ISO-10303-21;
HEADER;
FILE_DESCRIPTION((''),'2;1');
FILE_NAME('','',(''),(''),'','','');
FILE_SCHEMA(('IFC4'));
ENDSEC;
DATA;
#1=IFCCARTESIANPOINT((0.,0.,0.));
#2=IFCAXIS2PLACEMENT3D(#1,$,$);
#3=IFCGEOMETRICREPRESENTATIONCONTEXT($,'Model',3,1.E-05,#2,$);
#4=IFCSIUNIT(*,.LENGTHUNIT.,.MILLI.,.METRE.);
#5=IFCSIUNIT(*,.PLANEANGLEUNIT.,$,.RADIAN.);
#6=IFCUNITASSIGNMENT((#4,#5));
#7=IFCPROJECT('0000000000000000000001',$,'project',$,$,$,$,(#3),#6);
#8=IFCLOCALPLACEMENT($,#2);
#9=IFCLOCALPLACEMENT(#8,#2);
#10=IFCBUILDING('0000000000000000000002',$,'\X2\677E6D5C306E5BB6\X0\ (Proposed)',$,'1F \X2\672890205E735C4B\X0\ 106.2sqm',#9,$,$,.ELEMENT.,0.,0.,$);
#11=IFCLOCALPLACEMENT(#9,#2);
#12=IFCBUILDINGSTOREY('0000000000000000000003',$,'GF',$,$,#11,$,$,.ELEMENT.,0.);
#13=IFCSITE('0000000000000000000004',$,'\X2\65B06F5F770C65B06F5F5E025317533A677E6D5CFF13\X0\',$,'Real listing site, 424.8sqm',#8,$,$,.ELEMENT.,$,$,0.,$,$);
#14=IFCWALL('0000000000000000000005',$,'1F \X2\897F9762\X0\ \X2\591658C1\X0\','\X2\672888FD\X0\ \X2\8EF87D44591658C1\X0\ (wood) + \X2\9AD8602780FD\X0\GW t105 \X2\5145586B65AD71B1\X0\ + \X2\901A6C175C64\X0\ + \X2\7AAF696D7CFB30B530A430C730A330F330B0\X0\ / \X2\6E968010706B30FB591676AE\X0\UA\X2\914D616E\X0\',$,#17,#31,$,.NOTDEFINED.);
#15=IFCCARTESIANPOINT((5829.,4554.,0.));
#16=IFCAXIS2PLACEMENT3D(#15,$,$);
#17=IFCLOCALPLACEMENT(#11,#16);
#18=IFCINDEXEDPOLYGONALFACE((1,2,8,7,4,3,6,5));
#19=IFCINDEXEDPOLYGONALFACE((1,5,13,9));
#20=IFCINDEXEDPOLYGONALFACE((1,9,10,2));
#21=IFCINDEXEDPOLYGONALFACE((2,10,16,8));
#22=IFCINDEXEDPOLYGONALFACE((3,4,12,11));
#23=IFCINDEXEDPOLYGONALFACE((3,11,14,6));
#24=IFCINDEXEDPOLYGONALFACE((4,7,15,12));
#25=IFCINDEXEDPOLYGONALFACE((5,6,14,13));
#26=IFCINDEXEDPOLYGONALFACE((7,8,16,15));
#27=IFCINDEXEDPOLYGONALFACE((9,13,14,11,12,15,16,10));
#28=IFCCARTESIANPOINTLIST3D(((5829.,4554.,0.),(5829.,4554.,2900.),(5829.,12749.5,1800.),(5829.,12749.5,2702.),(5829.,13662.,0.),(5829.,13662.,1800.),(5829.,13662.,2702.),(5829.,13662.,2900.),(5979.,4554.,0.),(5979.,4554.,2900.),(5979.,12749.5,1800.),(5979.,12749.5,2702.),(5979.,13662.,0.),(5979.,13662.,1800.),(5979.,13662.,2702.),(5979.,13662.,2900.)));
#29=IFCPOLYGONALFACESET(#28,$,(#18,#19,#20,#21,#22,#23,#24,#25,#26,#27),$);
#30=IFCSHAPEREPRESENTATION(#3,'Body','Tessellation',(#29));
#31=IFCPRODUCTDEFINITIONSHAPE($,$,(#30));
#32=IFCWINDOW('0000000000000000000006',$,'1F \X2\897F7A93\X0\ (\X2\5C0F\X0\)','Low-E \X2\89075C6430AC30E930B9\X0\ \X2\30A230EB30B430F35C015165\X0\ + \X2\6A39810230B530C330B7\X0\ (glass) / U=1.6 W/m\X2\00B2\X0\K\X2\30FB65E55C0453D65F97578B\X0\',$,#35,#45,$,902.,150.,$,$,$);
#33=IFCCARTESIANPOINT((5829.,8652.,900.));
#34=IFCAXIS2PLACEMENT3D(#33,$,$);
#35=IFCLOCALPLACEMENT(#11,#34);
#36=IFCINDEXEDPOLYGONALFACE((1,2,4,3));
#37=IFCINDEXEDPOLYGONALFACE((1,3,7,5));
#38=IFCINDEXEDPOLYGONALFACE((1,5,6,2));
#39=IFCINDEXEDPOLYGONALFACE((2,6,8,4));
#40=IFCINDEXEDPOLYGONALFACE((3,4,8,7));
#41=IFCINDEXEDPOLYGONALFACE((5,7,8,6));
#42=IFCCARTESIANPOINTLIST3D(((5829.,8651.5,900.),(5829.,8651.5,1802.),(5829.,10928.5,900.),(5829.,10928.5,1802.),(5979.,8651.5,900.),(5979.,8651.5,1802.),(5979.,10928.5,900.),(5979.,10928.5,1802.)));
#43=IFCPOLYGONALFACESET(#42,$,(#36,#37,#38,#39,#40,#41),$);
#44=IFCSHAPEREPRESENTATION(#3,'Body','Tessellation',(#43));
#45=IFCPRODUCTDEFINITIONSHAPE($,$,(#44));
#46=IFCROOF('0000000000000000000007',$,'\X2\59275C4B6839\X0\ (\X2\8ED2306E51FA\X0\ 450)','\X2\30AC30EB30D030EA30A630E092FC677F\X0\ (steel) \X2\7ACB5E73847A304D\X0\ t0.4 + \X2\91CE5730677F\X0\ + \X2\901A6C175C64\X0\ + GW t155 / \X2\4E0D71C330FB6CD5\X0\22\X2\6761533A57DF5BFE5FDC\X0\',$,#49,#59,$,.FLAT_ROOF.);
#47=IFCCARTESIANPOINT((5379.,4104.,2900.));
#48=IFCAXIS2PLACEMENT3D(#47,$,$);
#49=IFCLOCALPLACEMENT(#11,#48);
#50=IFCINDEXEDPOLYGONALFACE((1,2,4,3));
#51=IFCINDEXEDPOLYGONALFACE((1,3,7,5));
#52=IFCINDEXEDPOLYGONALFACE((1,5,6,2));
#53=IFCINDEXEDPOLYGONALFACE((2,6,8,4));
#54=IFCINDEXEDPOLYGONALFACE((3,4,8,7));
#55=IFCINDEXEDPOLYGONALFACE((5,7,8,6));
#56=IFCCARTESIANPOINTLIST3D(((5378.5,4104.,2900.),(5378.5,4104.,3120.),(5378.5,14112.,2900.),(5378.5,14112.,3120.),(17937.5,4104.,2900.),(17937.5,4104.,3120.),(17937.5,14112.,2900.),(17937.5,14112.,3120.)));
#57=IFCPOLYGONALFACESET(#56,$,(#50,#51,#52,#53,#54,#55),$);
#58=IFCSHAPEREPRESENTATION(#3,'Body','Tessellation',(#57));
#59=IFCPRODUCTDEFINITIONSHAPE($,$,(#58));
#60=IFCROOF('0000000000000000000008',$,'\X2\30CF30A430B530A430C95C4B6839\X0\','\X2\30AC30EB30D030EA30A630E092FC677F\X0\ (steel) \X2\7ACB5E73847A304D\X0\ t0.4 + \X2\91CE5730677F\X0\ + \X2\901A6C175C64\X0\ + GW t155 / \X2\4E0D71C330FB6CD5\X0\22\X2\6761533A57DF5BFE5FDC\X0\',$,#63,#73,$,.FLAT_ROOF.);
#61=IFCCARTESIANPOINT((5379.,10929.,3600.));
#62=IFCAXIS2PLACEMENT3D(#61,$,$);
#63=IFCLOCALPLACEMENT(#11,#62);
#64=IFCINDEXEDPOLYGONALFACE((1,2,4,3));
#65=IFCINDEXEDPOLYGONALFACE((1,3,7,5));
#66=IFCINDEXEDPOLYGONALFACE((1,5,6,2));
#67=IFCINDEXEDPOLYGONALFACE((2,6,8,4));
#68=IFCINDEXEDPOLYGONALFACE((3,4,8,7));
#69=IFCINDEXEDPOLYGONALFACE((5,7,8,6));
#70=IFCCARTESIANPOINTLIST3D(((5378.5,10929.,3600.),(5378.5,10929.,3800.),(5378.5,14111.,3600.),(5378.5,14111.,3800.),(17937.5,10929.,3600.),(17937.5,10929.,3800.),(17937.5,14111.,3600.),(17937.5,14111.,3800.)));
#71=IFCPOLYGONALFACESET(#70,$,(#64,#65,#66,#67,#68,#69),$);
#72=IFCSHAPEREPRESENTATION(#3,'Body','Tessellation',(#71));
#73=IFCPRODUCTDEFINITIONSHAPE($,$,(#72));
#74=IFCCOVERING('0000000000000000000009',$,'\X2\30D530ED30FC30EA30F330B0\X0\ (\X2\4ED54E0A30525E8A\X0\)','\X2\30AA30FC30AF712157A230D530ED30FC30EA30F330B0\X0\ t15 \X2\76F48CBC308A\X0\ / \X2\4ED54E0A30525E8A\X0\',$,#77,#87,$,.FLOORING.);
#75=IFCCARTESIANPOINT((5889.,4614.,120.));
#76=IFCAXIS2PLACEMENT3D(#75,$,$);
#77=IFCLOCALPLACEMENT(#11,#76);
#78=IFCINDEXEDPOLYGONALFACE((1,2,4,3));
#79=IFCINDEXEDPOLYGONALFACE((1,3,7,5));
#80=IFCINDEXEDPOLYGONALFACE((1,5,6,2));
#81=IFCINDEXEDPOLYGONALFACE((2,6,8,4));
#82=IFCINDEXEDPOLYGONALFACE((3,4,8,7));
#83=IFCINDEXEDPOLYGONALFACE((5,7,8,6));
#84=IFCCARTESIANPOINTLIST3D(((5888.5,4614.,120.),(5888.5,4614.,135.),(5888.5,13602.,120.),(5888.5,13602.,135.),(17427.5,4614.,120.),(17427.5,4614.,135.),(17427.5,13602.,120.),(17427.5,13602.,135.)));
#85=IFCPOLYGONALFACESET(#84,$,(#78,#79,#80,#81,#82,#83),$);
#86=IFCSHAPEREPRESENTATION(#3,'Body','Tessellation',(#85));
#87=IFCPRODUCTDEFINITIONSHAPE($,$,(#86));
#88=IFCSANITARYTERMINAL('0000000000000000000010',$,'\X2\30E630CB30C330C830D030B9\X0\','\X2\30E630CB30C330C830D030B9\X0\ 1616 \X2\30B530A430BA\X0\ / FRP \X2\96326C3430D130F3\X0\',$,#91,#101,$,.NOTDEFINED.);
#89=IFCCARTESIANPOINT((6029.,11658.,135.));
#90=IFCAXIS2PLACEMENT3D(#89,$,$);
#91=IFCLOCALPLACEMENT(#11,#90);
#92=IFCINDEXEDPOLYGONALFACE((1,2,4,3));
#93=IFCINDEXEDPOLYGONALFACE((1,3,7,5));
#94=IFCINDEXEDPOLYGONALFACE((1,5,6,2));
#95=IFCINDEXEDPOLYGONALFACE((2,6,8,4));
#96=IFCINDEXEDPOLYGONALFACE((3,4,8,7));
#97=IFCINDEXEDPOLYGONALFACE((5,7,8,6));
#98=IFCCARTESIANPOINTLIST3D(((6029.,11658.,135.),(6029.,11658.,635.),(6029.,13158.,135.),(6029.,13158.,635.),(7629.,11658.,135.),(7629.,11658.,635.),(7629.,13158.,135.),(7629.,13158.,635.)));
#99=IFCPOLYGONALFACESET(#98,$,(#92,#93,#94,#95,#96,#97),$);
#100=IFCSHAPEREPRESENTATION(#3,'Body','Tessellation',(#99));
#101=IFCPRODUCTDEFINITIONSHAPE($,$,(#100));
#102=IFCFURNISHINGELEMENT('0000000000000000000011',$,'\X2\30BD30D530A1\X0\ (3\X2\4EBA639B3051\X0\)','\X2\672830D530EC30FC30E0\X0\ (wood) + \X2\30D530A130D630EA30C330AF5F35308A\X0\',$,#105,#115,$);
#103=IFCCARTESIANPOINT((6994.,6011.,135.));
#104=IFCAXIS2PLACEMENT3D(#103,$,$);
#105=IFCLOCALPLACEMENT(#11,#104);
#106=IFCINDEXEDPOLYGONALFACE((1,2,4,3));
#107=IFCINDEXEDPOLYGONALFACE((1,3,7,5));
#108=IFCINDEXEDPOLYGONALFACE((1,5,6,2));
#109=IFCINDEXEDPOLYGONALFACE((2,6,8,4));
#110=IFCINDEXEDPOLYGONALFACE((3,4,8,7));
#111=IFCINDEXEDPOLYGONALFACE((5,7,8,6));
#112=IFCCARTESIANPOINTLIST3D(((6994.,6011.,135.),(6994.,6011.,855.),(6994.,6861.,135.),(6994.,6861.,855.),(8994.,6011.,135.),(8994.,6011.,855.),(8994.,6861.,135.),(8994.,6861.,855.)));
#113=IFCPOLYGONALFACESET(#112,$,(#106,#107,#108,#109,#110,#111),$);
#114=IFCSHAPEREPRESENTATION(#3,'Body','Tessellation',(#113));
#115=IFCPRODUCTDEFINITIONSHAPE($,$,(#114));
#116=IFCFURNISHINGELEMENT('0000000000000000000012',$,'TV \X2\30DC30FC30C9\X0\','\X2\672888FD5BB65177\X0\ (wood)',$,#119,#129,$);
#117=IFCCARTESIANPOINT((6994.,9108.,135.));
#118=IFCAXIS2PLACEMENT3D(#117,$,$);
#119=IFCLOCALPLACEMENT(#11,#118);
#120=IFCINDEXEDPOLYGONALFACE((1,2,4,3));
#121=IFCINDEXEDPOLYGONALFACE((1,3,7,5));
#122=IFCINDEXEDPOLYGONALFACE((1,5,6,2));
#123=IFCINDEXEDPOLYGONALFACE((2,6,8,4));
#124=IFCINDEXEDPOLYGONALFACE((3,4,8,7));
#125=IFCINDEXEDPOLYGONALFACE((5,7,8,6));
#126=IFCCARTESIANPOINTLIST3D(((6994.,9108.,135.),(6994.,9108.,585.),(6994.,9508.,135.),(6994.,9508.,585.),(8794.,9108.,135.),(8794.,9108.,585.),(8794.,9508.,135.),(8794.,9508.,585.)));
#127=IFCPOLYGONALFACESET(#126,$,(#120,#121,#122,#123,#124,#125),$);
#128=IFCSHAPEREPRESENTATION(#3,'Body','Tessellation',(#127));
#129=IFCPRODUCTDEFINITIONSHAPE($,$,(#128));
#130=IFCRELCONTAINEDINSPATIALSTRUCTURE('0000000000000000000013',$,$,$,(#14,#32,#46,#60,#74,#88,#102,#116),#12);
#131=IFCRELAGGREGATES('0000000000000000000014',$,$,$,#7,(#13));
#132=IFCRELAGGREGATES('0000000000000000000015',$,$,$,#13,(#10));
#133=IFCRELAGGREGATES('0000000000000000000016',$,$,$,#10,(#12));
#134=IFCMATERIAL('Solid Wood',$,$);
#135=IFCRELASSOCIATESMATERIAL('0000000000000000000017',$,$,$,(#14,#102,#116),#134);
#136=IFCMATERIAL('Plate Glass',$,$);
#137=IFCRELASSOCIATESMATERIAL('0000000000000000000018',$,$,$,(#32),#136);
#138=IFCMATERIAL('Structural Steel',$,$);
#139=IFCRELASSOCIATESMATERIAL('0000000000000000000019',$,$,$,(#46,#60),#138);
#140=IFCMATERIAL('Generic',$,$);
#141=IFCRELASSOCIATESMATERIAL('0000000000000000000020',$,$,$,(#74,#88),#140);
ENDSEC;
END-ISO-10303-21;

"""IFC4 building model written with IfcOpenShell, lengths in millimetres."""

from ifc_helpers import new_model, si_unit, frame, frame_2d, origin, place, context, project, spatial, rectangle, extrude, material, element, fill, save


model = new_model("IFC4")

# Units and contexts
model_context = context("Model", 3, precision=1e-05, world=origin())
ifc_project = project(units=[si_unit("LENGTHUNIT", "METRE", prefix="MILLI"), si_unit("PLANEANGLEUNIT", "RADIAN")], contexts=[model_context])

# Site, building, storey
site_placement = place(None, origin())
site = spatial("IfcSite", under=ifc_project, at=site_placement, Name="新潟県新潟市北区松浜３", ObjectType="Real listing site, 424.8sqm", CompositionType="ELEMENT", RefElevation=0.0)
building_placement = place(site_placement, origin())
building = spatial("IfcBuilding", under=site, at=building_placement, Name="松浜の家 (Proposed)", ObjectType="1F 木造平屋 106.2sqm", CompositionType="ELEMENT", ElevationOfRefHeight=0.0, ElevationOfTerrain=0.0)
storey_placement = place(building_placement, origin())
storey = spatial("IfcBuildingStorey", under=building, at=storey_placement, Name="GF", CompositionType="ELEMENT", Elevation=0.0)

# Shared definitions
ifc_material_1 = material(Name="Solid Wood")

# Shared definitions
ifc_material_2 = material(Name="Plate Glass")

# Wall, opening, window
wall_1_placement = place(storey_placement, frame((5829.0, 4554.0, 0.0)))
wall_1 = element("IfcWall", 1, at=wall_1_placement, inside=storey, material=ifc_material_1, Name="1F 西面 外壁", Description="木製 軸組外壁 (wood) + 高性能GW t105 充填断熱 + 通気層 + 窯業系サイディング / 準耐火・外皮UA配慮", PredefinedType="NOTDEFINED", context=model_context, shape_type="SweptSolid", body=[
    extrude(rectangle(XDim=150.0, YDim=9108.0, at=frame_2d((75.0, 4554.0))), frame((5829.0, 4554.0, 0.0)), (0.0, 0.0, 1.0), 2900.0),
])
opening_1_placement = place(storey_placement, frame((5829.0, 8652.0, 900.0)))
opening_1 = element("IfcOpeningElement", 2, at=opening_1_placement, cuts=wall_1, PredefinedType="NOTDEFINED", context=model_context, shape_type="SweptSolid", body=[
    extrude(rectangle(XDim=150.0, YDim=2277.0, at=frame_2d((75.0, 1138.0))), frame((5829.0, 8652.0, 900.0)), (0.0, 0.0, 1.0), 902.0),
])
window_1_placement = place(storey_placement, frame((5829.0, 8652.0, 900.0)))
window_1 = element("IfcWindow", 3, at=window_1_placement, inside=storey, material=ifc_material_2, Name="1F 西窓 (小)", Description="Low-E 複層ガラス アルゴン封入 + 樹脂サッシ (glass) / U=1.6 W/m²K・日射取得型", OverallHeight=902.0, OverallWidth=150.0, context=model_context, shape_type="SweptSolid", body=[
    extrude(rectangle(XDim=150.0, YDim=2277.0, at=frame_2d((75.0, 1138.0))), frame((5829.0, 8652.0, 900.0)), (0.0, 0.0, 1.0), 902.0),
])
fill(opening_1, window_1)

# Roofs
ifc_material_3 = material(Name="Structural Steel")
roof_1_placement = place(storey_placement, frame((5379.0, 4104.0, 2900.0)))
element("IfcRoof", 4, at=roof_1_placement, inside=storey, material=ifc_material_3, Name="大屋根 (軒の出 450)", Description="ガルバリウム鋼板 (steel) 立平葺き t0.4 + 野地板 + 通気層 + GW t155 / 不燃・法22条区域対応", PredefinedType="FLAT_ROOF", context=model_context, shape_type="SweptSolid", body=[
    extrude(rectangle(XDim=12559.0, YDim=10008.0, at=frame_2d((6279.0, 5004.0))), frame((5379.0, 4104.0, 2900.0)), (0.0, 0.0, 1.0), 220.0),
])
roof_2_placement = place(storey_placement, frame((5379.0, 10929.0, 3600.0)))
element("IfcRoof", 5, at=roof_2_placement, inside=storey, material=ifc_material_3, Name="ハイサイド屋根", Description="ガルバリウム鋼板 (steel) 立平葺き t0.4 + 野地板 + 通気層 + GW t155 / 不燃・法22条区域対応", PredefinedType="FLAT_ROOF", context=model_context, shape_type="SweptSolid", body=[
    extrude(rectangle(XDim=12559.0, YDim=3182.0, at=frame_2d((6279.0, 1591.0))), frame((5379.0, 10929.0, 3600.0)), (0.0, 0.0, 1.0), 200.0),
])

# Covering
ifc_material_4 = material(Name="Generic")
covering_placement = place(storey_placement, frame((5889.0, 4614.0, 120.0)))
element("IfcCovering", 6, at=covering_placement, inside=storey, material=ifc_material_4, Name="フローリング (仕上げ床)", Description="オーク無垢フローリング t15 直貼り / 仕上げ床", PredefinedType="FLOORING", context=model_context, shape_type="SweptSolid", body=[
    extrude(rectangle(XDim=11539.0, YDim=8988.0, at=frame_2d((5769.0, 4494.0))), frame((5889.0, 4614.0, 120.0)), (0.0, 0.0, 1.0), 15.0),
])

# Sanitary terminal
sanitary_terminal_placement = place(storey_placement, frame((6029.0, 11658.0, 135.0)))
element("IfcSanitaryTerminal", 7, at=sanitary_terminal_placement, inside=storey, material=ifc_material_4, Name="ユニットバス", Description="ユニットバス 1616 サイズ / FRP 防水パン", PredefinedType="NOTDEFINED", context=model_context, shape_type="SweptSolid", body=[
    extrude(rectangle(XDim=1600.0, YDim=1500.0, at=frame_2d((800.0, 750.0))), frame((6029.0, 11658.0, 135.0)), (0.0, 0.0, 1.0), 500.0),
])

# Furnishing elements
furnishing_1_placement = place(storey_placement, frame((6994.0, 6011.0, 135.0)))
element("IfcFurnishingElement", 8, at=furnishing_1_placement, inside=storey, material=ifc_material_1, Name="ソファ (3人掛け)", Description="木フレーム (wood) + ファブリック張り", context=model_context, shape_type="SweptSolid", body=[
    extrude(rectangle(XDim=2000.0, YDim=850.0, at=frame_2d((1000.0, 425.0))), frame((6994.0, 6011.0, 135.0)), (0.0, 0.0, 1.0), 720.0),
])
furnishing_2_placement = place(storey_placement, frame((6994.0, 9108.0, 135.0)))
element("IfcFurnishingElement", 9, at=furnishing_2_placement, inside=storey, material=ifc_material_1, Name="TV ボード", Description="木製家具 (wood)", context=model_context, shape_type="SweptSolid", body=[
    extrude(rectangle(XDim=1800.0, YDim=400.0, at=frame_2d((900.0, 200.0))), frame((6994.0, 9108.0, 135.0)), (0.0, 0.0, 1.0), 450.0),
])

save(model, "model.ifc")
